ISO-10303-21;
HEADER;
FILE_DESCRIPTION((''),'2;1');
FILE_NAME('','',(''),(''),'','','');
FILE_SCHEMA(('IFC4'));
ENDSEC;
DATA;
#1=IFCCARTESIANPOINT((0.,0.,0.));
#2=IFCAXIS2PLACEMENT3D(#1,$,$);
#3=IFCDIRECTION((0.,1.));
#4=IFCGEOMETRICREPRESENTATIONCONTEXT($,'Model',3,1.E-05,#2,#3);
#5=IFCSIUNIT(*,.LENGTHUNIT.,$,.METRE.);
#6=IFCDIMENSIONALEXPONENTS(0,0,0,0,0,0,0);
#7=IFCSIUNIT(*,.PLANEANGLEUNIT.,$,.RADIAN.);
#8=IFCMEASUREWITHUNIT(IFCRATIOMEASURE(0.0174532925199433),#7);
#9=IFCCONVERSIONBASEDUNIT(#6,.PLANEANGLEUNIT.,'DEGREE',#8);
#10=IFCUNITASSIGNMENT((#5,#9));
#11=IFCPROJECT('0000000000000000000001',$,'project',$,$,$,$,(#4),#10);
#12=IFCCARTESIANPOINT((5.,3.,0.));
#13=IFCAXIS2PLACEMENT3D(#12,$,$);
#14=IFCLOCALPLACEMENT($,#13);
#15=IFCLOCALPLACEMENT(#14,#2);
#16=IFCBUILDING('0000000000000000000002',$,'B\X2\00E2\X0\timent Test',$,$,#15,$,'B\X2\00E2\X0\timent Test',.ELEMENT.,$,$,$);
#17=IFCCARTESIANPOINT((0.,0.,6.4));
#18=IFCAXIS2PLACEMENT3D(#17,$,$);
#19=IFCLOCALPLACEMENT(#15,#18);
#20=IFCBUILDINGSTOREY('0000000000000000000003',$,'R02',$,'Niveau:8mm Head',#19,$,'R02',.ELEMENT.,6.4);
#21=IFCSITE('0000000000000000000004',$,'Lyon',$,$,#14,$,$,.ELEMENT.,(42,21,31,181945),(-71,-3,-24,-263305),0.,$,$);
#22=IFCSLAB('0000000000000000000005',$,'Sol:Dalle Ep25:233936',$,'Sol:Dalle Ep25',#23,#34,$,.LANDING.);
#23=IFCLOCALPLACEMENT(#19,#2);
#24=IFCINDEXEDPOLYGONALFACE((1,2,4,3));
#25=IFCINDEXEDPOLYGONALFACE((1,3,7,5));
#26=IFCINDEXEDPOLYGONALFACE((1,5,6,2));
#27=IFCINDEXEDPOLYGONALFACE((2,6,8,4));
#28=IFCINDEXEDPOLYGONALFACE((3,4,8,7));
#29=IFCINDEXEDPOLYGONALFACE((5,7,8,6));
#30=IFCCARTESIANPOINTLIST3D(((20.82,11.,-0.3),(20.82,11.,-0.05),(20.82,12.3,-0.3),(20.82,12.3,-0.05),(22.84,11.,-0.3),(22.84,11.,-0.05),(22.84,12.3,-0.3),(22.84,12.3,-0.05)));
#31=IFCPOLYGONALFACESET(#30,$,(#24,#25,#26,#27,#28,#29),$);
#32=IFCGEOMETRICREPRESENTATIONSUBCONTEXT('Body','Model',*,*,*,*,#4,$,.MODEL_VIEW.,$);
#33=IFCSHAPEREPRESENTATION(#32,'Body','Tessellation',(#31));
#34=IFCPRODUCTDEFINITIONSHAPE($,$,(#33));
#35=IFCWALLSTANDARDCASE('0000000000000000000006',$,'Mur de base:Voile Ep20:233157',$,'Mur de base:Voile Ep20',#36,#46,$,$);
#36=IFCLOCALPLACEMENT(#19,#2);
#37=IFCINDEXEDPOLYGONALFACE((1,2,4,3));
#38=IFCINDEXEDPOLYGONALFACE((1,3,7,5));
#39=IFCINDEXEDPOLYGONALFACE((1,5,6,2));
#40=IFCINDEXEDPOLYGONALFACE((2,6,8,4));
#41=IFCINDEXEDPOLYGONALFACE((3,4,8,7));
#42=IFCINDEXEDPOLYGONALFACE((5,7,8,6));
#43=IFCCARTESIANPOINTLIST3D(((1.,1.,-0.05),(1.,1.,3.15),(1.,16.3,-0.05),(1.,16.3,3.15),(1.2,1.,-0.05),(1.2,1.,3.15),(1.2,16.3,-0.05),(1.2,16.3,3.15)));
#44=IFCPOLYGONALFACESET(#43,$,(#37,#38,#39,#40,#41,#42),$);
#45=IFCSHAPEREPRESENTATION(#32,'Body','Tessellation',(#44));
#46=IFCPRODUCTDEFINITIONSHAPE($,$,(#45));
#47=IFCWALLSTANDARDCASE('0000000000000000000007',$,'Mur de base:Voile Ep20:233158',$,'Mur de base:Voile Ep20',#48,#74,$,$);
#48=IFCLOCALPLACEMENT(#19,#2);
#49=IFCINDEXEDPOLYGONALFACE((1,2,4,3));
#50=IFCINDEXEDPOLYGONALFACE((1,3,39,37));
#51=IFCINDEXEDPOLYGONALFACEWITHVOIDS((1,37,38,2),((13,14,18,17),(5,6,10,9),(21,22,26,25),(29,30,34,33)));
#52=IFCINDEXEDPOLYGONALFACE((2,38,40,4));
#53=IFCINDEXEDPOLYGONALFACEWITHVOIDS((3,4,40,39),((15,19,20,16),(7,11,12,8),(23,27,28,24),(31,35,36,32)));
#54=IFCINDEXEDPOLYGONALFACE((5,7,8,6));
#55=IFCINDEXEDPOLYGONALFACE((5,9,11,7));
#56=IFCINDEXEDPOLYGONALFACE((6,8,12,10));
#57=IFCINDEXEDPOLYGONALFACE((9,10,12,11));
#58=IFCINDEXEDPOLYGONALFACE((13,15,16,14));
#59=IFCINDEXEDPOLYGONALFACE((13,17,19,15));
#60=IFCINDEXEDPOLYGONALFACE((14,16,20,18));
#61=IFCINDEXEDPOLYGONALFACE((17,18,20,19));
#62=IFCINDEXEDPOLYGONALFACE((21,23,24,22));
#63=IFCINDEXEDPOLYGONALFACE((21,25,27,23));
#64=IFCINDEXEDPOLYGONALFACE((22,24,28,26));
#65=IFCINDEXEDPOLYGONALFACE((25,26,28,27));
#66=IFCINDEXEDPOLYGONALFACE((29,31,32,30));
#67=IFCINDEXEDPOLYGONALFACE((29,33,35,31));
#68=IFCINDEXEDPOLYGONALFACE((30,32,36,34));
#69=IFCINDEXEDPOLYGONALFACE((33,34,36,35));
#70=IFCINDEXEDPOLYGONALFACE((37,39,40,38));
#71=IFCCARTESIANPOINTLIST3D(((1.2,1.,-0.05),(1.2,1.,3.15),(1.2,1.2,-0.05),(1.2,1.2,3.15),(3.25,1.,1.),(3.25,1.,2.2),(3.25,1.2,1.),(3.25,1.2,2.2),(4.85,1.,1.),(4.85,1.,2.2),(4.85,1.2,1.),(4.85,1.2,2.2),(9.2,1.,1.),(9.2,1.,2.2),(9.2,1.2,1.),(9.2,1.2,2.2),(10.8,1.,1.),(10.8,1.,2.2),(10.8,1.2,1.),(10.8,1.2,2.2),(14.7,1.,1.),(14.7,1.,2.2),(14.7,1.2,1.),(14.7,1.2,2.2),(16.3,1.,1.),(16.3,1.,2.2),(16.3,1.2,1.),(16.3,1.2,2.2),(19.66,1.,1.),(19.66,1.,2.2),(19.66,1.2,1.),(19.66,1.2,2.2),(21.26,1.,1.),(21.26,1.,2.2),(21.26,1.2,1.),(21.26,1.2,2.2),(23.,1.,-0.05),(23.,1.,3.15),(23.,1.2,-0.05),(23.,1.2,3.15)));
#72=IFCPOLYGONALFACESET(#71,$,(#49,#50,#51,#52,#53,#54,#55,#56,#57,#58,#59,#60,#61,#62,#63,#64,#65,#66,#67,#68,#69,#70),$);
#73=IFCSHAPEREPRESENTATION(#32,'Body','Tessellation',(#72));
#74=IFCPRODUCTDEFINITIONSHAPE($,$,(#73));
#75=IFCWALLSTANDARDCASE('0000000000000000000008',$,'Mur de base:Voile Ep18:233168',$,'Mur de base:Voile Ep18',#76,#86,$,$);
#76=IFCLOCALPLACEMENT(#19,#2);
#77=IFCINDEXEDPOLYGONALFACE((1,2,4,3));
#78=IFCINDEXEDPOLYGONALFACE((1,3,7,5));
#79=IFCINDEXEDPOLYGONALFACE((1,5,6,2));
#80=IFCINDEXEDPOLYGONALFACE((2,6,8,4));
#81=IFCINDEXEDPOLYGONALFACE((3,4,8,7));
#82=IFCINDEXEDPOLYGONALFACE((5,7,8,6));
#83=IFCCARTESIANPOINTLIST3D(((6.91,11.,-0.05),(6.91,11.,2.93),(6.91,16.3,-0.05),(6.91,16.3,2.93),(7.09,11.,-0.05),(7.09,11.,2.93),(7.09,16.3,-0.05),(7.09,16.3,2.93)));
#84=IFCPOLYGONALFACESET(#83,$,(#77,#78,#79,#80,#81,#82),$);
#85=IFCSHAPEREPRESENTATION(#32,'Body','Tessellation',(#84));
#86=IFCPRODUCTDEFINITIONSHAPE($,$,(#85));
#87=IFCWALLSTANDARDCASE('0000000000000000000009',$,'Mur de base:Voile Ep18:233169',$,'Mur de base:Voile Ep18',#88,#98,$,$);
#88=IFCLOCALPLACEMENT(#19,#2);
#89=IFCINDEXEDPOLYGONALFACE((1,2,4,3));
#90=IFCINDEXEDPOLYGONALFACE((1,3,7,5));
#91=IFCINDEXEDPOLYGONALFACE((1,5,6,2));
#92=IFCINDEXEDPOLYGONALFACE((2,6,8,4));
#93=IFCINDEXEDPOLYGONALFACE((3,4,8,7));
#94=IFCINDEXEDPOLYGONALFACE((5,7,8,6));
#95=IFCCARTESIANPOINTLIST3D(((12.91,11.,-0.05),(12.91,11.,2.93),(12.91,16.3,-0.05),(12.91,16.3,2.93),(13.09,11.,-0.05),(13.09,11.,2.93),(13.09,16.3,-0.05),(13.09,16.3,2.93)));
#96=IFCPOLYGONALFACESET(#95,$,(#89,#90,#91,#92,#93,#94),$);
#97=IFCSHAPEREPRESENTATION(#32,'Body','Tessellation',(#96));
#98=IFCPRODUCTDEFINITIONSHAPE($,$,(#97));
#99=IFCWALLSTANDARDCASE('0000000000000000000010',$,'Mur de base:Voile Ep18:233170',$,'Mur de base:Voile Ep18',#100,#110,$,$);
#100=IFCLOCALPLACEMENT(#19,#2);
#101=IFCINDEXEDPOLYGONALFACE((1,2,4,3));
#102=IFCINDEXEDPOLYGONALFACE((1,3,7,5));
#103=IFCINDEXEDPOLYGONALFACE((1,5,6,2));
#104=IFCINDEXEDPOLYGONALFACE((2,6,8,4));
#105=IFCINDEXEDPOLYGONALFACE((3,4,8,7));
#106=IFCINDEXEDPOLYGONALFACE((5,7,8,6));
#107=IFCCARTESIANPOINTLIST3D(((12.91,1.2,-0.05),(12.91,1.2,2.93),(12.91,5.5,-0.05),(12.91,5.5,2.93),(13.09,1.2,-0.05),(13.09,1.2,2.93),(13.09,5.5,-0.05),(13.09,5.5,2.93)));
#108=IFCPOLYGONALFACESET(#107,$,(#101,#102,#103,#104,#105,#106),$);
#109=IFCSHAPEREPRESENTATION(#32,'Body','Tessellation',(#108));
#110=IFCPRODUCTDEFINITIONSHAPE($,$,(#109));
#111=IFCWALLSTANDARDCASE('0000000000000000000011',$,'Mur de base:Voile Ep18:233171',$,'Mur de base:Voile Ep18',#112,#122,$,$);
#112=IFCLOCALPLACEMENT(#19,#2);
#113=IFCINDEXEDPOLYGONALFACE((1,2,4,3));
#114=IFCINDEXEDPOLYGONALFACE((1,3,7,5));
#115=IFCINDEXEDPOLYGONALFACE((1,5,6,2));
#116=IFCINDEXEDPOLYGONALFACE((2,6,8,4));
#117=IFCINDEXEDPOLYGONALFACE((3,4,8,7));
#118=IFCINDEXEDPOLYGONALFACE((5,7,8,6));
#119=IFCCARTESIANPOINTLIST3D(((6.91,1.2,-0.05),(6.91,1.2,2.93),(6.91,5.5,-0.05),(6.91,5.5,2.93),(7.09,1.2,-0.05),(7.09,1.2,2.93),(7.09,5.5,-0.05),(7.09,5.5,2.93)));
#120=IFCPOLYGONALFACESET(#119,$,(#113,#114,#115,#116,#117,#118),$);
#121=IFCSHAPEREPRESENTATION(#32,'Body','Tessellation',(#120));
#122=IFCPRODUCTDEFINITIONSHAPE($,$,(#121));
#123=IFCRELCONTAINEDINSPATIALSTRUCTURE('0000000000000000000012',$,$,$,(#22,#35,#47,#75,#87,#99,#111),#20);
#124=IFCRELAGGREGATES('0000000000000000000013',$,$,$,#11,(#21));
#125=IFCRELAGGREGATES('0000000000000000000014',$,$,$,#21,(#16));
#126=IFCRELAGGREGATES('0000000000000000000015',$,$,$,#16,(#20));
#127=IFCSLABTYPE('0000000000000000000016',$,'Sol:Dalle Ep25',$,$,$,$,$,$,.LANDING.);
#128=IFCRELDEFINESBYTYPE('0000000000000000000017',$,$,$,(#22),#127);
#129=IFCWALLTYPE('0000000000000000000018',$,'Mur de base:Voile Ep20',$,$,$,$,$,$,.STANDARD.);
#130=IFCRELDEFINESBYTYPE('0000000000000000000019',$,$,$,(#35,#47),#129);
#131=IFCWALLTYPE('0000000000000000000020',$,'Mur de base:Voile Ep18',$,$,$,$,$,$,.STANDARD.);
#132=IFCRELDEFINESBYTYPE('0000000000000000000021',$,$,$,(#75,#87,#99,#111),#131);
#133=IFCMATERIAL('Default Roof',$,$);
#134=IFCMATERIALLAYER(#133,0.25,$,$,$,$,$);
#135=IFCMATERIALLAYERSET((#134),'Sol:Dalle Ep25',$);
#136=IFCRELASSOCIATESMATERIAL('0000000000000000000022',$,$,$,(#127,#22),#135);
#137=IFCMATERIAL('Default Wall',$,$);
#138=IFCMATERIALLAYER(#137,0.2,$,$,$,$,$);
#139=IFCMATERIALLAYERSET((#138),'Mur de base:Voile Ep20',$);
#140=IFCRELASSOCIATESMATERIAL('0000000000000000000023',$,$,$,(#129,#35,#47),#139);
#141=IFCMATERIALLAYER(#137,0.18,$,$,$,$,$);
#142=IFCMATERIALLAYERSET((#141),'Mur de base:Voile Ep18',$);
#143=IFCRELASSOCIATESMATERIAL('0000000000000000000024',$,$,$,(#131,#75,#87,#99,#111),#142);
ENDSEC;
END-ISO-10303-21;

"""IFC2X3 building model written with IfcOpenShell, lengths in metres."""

from ifc_helpers import new_model, entity, si_unit, converted_unit, direction, frame, frame_2d, origin, origin_2d_with_axis, place, context, subcontext, project, spatial, rectangle, extrude, material, layer, layer_set, layer_usage, type_object, element, save


model = new_model("IFC2X3")

# Units and contexts
model_context = context("Model", 3, precision=1e-05, world=origin(), true_north=direction((0.0, 1.0)))
body_context = subcontext(model_context, "Body", "Model", "MODEL_VIEW")
ifc_project = project(units=[si_unit("LENGTHUNIT", "METRE"), converted_unit("PLANEANGLEUNIT", "DEGREE", entity("IfcRatioMeasure", 0.0174532925199433), si_unit("PLANEANGLEUNIT", "RADIAN"), dimensions=[0, 0, 0, 0, 0, 0, 0])], contexts=[model_context])

# Site, building, storey
site_placement = place(None, frame((5.0, 3.0, 0.0)))
site = spatial("IfcSite", under=ifc_project, at=site_placement, Name="Lyon", CompositionType="ELEMENT", RefLatitude=(42, 21, 31, 181945), RefLongitude=(-71, -3, -24, -263305), RefElevation=0.0)
building_placement = place(site_placement, origin())
building = spatial("IfcBuilding", under=site, at=building_placement, Name="Bâtiment Test", LongName="Bâtiment Test", CompositionType="ELEMENT")
storey_placement = place(building_placement, frame((0.0, 0.0, 6.4)))
storey = spatial("IfcBuildingStorey", under=building, at=storey_placement, Name="R02", ObjectType="Niveau:8mm Head", LongName="R02", CompositionType="ELEMENT", Elevation=6.4)

# Slab
ifc_material_1 = material(Name="Default Roof")
ifc_layer_1 = layer(ifc_material_1, 0.25)
ifc_layer_set_1 = layer_set([ifc_layer_1], Name="Sol:Dalle Ep25")
ifc_layer_usage_1 = layer_usage(ifc_layer_set_1, "AXIS3", "POSITIVE", 0.0)
slab_type_1 = type_object("IfcSlabType", Name="Sol:Dalle Ep25", PredefinedType="LANDING", material=ifc_layer_set_1)
slab_1_placement = place(storey_placement, origin())
element("IfcSlab", 1, at=slab_1_placement, inside=storey, type_object=slab_type_1, material=ifc_layer_usage_1, Name="Sol:Dalle Ep25:233936", ObjectType="Sol:Dalle Ep25", PredefinedType="LANDING", context=body_context, shape_type="SweptSolid", body=[
    extrude(rectangle(XDim=1.3, YDim=2.02, at=frame_2d((0.0, 0.0), x_axis=(1.0, 0.0))), frame((21.83, 11.65, -0.05), z_axis=(0.0, 0.0, -1.0), x_axis=(0.0, 1.0, 0.0)), (0.0, 0.0, 1.0), 0.25),
])

# Wall
ifc_material_2 = material(Name="Default Wall")
ifc_layer_2 = layer(ifc_material_2, 0.2)
ifc_layer_set_2 = layer_set([ifc_layer_2], Name="Mur de base:Voile Ep20")
ifc_layer_usage_2 = layer_usage(ifc_layer_set_2, "AXIS2", "POSITIVE", -0.1)
wall_type_1 = type_object("IfcWallType", Name="Mur de base:Voile Ep20", PredefinedType="STANDARD", material=ifc_layer_set_2)
wall_1_placement = place(storey_placement, frame((1.1, 16.3, -0.05), z_axis=(0.0, 0.0, 1.0), x_axis=(0.0, -1.0, 0.0)))
element("IfcWallStandardCase", 2, at=wall_1_placement, inside=storey, type_object=wall_type_1, material=ifc_layer_usage_2, Name="Mur de base:Voile Ep20:233157", ObjectType="Mur de base:Voile Ep20", context=body_context, shape_type="SweptSolid", body=[
    extrude(rectangle(XDim=15.3, YDim=0.2, at=frame_2d((7.65, 0.0), x_axis=(-1.0, 0.0))), origin(), (0.0, 0.0, 1.0), 3.2),
])

# Wall, openings
ifc_layer_usage_3 = layer_usage(ifc_layer_set_2, "AXIS2", "POSITIVE", -0.1)
wall_2_placement = place(storey_placement, frame((1.2, 1.1, -0.05)))
wall_2 = element("IfcWallStandardCase", 3, at=wall_2_placement, inside=storey, type_object=wall_type_1, material=ifc_layer_usage_3, Name="Mur de base:Voile Ep20:233158", ObjectType="Mur de base:Voile Ep20", context=body_context, shape_type="SweptSolid", body=[
    extrude(rectangle(XDim=21.8, YDim=0.2, at=frame_2d((10.9, 0.0), x_axis=(-1.0, 0.0))), origin(), (0.0, 0.0, 1.0), 3.2),
])
opening_1_placement = place(wall_2_placement, origin())
element("IfcOpeningElement", 4, at=opening_1_placement, cuts=wall_2, ObjectType="Opening", context=body_context, shape_type="SweptSolid", body=[
    extrude(rectangle(XDim=1.2, YDim=1.6, at=frame_2d((0.0, 0.0), x_axis=(0.0, 1.0))), frame((2.85, -0.1, 1.65), z_axis=(0.0, 1.0, 0.0), x_axis=(1.0, 0.0, 0.0)), (0.0, 0.0, 1.0), 0.2),
])
opening_2_placement = place(wall_2_placement, origin())
element("IfcOpeningElement", 5, at=opening_2_placement, cuts=wall_2, ObjectType="Opening", context=body_context, shape_type="SweptSolid", body=[
    extrude(rectangle(XDim=1.2, YDim=1.6, at=origin_2d_with_axis()), frame((8.8, -0.1, 1.65), z_axis=(0.0, 1.0, 0.0), x_axis=(0.0, 0.0, -1.0)), (0.0, 0.0, 1.0), 0.2),
])
opening_3_placement = place(wall_2_placement, origin())
element("IfcOpeningElement", 6, at=opening_3_placement, cuts=wall_2, ObjectType="Opening", context=body_context, shape_type="SweptSolid", body=[
    extrude(rectangle(XDim=1.2, YDim=1.6, at=frame_2d((0.0, 0.0), x_axis=(0.0, 1.0))), frame((14.3, -0.1, 1.65), z_axis=(0.0, 1.0, 0.0), x_axis=(1.0, 0.0, 0.0)), (0.0, 0.0, 1.0), 0.2),
])
opening_4_placement = place(wall_2_placement, origin())
element("IfcOpeningElement", 7, at=opening_4_placement, cuts=wall_2, ObjectType="Opening", context=body_context, shape_type="SweptSolid", body=[
    extrude(rectangle(XDim=1.2, YDim=1.6, at=origin_2d_with_axis()), frame((19.26, -0.1, 1.65), z_axis=(0.0, 1.0, 0.0), x_axis=(0.0, 0.0, -1.0)), (0.0, 0.0, 1.0), 0.2),
])

# Walls
ifc_layer_3 = layer(ifc_material_2, 0.18)
ifc_layer_set_3 = layer_set([ifc_layer_3], Name="Mur de base:Voile Ep18")
ifc_layer_usage_4 = layer_usage(ifc_layer_set_3, "AXIS2", "NEGATIVE", 0.09)
wall_type_2 = type_object("IfcWallType", Name="Mur de base:Voile Ep18", PredefinedType="STANDARD", material=ifc_layer_set_3)
wall_3_placement = place(storey_placement, frame((7.0, 16.3, -0.05), z_axis=(0.0, 0.0, 1.0), x_axis=(0.0, -1.0, 0.0)))
element("IfcWallStandardCase", 8, at=wall_3_placement, inside=storey, type_object=wall_type_2, material=ifc_layer_usage_4, Name="Mur de base:Voile Ep18:233168", ObjectType="Mur de base:Voile Ep18", context=body_context, shape_type="SweptSolid", body=[
    extrude(rectangle(XDim=5.3, YDim=0.18, at=frame_2d((2.65, 0.0), x_axis=(-1.0, 0.0))), origin(), (0.0, 0.0, 1.0), 2.98),
])
ifc_layer_usage_5 = layer_usage(ifc_layer_set_3, "AXIS2", "NEGATIVE", 0.09)
wall_4_placement = place(storey_placement, frame((13.0, 16.3, -0.05), z_axis=(0.0, 0.0, 1.0), x_axis=(0.0, -1.0, 0.0)))
element("IfcWallStandardCase", 9, at=wall_4_placement, inside=storey, type_object=wall_type_2, material=ifc_layer_usage_5, Name="Mur de base:Voile Ep18:233169", ObjectType="Mur de base:Voile Ep18", context=body_context, shape_type="SweptSolid", body=[
    extrude(rectangle(XDim=5.3, YDim=0.18, at=frame_2d((2.65, 0.0), x_axis=(-1.0, 0.0))), origin(), (0.0, 0.0, 1.0), 2.98),
])
ifc_layer_usage_6 = layer_usage(ifc_layer_set_3, "AXIS2", "NEGATIVE", 0.09)
wall_5_placement = place(storey_placement, frame((13.0, 1.2, -0.05), z_axis=(0.0, 0.0, 1.0), x_axis=(0.0, 1.0, 0.0)))
element("IfcWallStandardCase", 10, at=wall_5_placement, inside=storey, type_object=wall_type_2, material=ifc_layer_usage_6, Name="Mur de base:Voile Ep18:233170", ObjectType="Mur de base:Voile Ep18", context=body_context, shape_type="SweptSolid", body=[
    extrude(rectangle(XDim=4.3, YDim=0.18, at=frame_2d((2.15, 0.0), x_axis=(-1.0, 0.0))), origin(), (0.0, 0.0, 1.0), 2.98),
])
ifc_layer_usage_7 = layer_usage(ifc_layer_set_3, "AXIS2", "NEGATIVE", 0.09)
wall_6_placement = place(storey_placement, frame((7.0, 1.2, -0.05), z_axis=(0.0, 0.0, 1.0), x_axis=(0.0, 1.0, 0.0)))
element("IfcWallStandardCase", 11, at=wall_6_placement, inside=storey, type_object=wall_type_2, material=ifc_layer_usage_7, Name="Mur de base:Voile Ep18:233171", ObjectType="Mur de base:Voile Ep18", context=body_context, shape_type="SweptSolid", body=[
    extrude(rectangle(XDim=4.3, YDim=0.18, at=frame_2d((2.15, 0.0), x_axis=(-1.0, 0.0))), origin(), (0.0, 0.0, 1.0), 2.98),
])

save(model, "model.ifc")
